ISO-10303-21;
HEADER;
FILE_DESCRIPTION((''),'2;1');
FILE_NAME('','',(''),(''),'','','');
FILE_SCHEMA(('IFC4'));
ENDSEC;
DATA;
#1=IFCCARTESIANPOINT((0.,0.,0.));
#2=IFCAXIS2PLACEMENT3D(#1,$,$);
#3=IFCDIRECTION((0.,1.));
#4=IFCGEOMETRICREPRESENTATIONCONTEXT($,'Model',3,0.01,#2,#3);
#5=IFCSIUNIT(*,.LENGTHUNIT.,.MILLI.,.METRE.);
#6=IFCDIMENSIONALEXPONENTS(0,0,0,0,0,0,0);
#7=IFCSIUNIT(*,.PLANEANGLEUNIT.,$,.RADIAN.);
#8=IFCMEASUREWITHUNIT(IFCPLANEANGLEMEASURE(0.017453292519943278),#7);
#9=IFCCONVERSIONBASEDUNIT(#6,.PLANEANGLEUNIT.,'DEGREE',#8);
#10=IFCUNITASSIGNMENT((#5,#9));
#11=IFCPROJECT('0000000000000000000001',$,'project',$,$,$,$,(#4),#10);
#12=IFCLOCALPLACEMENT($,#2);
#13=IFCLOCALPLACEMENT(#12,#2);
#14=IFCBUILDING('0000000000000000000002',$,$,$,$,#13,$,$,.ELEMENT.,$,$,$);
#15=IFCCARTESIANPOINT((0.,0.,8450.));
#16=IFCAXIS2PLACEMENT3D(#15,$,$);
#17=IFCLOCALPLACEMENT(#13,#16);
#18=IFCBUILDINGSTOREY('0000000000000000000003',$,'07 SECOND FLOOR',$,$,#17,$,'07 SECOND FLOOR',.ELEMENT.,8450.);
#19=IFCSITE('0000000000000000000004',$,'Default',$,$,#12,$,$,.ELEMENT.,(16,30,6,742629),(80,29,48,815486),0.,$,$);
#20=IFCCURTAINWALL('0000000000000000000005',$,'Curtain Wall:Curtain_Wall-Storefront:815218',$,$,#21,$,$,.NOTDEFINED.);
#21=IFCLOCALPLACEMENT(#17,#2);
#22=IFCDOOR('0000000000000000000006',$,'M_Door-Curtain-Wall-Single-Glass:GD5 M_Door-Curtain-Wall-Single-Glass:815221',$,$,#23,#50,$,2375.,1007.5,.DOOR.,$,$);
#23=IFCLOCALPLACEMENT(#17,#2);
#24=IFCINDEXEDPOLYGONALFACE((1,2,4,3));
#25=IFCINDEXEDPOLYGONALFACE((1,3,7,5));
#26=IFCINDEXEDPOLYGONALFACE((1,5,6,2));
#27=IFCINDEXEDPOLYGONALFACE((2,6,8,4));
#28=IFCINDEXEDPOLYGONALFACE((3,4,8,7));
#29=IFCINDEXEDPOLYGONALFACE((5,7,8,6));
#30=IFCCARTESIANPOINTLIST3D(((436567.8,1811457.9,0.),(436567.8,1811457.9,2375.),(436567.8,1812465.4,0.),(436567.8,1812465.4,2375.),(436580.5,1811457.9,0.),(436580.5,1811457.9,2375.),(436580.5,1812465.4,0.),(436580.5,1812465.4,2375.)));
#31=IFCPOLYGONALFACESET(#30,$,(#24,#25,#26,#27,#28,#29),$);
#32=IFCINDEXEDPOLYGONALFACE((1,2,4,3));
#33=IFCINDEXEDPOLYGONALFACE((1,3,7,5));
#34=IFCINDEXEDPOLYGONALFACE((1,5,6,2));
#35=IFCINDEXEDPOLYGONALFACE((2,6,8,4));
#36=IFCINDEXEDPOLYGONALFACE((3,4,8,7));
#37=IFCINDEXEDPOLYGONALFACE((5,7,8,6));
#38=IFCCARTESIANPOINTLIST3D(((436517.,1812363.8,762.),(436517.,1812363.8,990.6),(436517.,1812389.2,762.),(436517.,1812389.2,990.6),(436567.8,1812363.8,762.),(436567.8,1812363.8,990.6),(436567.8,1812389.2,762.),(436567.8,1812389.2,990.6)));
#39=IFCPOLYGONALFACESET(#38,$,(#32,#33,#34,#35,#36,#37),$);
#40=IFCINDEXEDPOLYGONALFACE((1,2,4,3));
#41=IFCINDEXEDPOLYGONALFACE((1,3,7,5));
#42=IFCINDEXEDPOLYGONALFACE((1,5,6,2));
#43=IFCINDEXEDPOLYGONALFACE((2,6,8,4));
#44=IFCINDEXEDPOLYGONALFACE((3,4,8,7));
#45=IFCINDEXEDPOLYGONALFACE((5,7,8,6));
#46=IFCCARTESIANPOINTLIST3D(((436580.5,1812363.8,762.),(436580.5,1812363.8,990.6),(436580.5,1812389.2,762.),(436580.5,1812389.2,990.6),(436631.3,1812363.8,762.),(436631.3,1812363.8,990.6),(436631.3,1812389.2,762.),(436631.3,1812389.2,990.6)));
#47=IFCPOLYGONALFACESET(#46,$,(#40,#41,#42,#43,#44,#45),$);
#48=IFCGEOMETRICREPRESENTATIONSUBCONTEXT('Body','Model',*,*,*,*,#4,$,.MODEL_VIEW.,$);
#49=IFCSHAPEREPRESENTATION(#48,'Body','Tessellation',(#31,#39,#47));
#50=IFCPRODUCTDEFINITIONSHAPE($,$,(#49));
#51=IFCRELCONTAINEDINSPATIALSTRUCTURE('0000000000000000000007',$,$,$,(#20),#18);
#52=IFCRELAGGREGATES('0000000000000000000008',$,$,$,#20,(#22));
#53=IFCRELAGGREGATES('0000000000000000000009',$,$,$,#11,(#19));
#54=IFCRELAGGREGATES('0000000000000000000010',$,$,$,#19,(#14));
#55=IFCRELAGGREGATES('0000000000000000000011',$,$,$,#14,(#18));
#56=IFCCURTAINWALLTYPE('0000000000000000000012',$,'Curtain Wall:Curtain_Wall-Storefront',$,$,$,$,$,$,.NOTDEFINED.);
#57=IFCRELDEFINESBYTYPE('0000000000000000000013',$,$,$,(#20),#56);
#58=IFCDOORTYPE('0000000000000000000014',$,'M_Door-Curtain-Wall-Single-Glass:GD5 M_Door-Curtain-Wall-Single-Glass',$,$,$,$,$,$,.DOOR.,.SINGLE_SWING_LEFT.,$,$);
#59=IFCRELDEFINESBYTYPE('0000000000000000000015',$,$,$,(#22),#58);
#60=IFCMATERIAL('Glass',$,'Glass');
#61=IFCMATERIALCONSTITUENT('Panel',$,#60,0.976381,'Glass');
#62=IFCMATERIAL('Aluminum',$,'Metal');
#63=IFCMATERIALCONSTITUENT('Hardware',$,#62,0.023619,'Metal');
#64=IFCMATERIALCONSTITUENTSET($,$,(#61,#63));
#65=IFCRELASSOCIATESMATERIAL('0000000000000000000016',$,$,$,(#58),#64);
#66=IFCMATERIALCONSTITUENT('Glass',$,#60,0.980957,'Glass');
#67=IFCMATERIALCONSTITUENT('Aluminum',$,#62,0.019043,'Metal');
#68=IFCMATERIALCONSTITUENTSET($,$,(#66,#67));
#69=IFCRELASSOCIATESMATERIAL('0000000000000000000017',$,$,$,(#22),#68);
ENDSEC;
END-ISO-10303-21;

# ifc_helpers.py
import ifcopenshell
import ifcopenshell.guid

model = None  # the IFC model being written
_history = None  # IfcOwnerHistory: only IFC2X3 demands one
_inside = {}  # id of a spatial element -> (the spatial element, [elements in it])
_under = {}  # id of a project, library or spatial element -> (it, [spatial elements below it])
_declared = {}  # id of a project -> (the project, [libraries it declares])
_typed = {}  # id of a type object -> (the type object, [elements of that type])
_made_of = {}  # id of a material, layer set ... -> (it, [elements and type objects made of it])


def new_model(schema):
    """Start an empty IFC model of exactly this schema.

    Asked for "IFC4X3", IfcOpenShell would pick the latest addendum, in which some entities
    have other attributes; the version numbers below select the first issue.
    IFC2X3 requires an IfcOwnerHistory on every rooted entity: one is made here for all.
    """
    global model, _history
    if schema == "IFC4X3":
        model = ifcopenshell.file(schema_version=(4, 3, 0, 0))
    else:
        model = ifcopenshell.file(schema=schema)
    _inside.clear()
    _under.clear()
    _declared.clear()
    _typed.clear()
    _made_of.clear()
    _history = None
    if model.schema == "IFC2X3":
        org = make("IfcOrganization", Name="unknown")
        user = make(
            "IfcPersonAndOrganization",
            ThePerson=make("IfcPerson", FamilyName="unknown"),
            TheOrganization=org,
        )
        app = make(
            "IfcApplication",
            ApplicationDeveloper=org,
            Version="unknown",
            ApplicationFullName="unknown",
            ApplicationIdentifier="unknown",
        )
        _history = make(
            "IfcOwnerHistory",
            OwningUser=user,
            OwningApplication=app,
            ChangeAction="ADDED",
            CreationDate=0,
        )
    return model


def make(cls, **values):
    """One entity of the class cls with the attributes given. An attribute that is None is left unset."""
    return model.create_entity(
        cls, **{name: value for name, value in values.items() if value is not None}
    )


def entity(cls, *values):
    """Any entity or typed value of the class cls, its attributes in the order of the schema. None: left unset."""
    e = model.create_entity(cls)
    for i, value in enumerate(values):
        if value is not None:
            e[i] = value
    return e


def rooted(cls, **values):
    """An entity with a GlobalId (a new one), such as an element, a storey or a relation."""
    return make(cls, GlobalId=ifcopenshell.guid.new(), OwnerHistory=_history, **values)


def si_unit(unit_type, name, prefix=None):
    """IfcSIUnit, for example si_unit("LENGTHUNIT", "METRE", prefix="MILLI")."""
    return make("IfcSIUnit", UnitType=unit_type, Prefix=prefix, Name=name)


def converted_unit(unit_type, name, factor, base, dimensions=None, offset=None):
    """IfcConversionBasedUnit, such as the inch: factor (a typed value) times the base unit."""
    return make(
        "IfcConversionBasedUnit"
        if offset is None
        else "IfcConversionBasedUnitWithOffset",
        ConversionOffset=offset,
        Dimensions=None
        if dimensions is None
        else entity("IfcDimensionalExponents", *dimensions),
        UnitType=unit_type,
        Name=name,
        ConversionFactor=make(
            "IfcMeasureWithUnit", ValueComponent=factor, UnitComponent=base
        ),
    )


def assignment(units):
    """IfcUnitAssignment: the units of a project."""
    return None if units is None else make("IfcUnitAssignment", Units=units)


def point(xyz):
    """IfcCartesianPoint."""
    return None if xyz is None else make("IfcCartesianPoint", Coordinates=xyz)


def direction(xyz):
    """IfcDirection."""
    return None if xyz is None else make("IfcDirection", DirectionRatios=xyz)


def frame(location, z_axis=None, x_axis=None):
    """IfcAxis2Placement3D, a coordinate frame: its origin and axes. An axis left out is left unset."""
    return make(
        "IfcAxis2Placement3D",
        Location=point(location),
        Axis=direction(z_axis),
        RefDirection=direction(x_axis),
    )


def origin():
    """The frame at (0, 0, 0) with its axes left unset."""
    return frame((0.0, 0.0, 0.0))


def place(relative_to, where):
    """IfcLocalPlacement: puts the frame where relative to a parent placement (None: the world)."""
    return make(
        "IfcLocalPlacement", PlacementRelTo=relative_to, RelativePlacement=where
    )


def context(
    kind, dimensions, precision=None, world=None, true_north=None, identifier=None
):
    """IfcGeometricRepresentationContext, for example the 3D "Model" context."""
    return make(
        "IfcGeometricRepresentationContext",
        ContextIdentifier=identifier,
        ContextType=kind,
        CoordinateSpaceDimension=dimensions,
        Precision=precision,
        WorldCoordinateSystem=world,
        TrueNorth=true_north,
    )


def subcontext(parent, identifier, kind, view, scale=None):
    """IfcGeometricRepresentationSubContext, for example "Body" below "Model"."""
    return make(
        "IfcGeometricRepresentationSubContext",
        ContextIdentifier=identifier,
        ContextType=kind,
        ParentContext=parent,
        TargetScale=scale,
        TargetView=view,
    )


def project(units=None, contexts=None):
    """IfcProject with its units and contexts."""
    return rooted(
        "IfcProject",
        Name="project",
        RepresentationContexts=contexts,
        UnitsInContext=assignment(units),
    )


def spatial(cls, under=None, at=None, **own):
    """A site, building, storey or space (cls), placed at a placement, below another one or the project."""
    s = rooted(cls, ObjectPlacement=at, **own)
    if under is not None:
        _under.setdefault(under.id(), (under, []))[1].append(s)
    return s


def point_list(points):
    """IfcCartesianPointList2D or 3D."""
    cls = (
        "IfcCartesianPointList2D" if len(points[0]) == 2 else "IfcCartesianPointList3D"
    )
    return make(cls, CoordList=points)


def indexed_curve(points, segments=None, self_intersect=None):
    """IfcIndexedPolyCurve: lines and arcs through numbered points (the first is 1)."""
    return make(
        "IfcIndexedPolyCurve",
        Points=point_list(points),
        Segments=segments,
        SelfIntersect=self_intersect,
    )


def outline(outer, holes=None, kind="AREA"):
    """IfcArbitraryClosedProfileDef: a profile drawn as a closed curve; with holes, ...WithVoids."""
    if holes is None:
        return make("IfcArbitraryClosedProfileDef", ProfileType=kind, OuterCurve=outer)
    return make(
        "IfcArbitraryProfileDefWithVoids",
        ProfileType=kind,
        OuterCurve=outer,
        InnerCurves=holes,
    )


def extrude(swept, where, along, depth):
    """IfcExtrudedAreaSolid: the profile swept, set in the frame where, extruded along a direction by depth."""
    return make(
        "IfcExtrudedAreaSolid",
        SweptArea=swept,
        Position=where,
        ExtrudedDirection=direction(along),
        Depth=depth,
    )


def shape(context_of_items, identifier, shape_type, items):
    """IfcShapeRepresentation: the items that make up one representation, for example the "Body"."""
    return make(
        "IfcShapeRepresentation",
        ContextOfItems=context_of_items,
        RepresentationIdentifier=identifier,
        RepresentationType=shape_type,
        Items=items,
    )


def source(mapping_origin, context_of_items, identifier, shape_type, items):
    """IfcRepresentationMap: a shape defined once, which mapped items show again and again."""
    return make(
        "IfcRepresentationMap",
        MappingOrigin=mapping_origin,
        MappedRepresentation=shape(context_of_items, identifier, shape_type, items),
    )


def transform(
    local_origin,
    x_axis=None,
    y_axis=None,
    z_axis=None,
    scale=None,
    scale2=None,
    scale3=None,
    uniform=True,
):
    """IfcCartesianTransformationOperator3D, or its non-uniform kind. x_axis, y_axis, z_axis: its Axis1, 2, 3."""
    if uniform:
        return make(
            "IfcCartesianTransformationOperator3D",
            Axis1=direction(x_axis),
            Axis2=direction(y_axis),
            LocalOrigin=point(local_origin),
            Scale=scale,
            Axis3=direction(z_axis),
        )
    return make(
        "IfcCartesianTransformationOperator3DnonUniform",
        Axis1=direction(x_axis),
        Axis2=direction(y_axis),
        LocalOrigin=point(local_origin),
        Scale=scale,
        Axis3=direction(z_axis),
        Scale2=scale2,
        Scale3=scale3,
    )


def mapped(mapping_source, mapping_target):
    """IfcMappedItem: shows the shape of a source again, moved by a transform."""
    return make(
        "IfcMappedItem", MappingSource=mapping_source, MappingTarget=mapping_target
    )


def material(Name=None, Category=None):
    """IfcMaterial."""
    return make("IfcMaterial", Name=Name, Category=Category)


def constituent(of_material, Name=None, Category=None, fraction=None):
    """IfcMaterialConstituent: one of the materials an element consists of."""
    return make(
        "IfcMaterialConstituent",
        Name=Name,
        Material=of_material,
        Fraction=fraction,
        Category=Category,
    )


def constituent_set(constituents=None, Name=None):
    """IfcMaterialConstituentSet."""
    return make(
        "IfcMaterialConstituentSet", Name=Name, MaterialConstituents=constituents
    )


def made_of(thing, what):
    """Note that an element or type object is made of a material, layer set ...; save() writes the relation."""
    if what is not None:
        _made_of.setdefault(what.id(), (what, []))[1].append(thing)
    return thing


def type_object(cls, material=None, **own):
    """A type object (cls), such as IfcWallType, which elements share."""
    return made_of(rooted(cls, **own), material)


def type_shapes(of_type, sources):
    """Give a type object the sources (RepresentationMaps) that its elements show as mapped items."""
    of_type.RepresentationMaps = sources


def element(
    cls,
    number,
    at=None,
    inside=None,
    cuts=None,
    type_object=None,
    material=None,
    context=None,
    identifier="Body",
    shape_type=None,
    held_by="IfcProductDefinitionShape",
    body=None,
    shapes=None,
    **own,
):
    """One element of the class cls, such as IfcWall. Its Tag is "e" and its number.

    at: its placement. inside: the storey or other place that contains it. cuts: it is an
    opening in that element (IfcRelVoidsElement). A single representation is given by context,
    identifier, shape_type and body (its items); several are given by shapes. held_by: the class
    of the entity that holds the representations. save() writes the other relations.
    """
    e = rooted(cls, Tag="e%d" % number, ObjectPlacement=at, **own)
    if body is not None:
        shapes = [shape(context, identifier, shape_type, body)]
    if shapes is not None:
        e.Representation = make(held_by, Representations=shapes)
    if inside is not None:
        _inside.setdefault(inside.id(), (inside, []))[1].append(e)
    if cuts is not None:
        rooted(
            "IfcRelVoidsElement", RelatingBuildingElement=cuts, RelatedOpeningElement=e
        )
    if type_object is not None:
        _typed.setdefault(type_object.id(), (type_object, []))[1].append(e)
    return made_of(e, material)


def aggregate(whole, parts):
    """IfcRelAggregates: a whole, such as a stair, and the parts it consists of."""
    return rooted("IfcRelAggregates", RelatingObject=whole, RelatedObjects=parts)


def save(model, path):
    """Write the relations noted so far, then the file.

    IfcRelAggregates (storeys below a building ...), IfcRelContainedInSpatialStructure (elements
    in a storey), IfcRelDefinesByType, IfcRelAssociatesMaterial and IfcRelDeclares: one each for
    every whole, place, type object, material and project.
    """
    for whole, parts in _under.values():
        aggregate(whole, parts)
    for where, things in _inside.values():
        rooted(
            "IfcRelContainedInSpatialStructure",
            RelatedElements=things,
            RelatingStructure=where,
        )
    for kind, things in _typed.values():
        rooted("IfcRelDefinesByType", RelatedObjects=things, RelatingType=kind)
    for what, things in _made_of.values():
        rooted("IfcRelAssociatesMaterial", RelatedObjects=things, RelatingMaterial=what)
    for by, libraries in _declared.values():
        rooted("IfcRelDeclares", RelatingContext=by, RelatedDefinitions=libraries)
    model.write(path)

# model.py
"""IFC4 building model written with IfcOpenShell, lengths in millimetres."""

from ifc_helpers import new_model, entity, si_unit, converted_unit, direction, frame, origin, place, context, subcontext, project, spatial, indexed_curve, outline, extrude, source, transform, mapped, material, constituent, constituent_set, type_object, type_shapes, element, aggregate, save


model = new_model("IFC4")

# Units and contexts
model_context = context("Model", 3, precision=0.01, world=origin(), true_north=direction((0.0, 1.0)))
body_context = subcontext(model_context, "Body", "Model", "MODEL_VIEW")
ifc_project = project(units=[si_unit("LENGTHUNIT", "METRE", prefix="MILLI"), converted_unit("PLANEANGLEUNIT", "DEGREE", entity("IfcPlaneAngleMeasure", 0.017453292519943278), si_unit("PLANEANGLEUNIT", "RADIAN"), dimensions=[0, 0, 0, 0, 0, 0, 0])], contexts=[model_context])

# Site, building, storey
site_placement = place(None, origin())
site = spatial("IfcSite", under=ifc_project, at=site_placement, Name="Default", CompositionType="ELEMENT", RefLatitude=(16, 30, 6, 742629), RefLongitude=(80, 29, 48, 815486), RefElevation=0.0)
building_placement = place(site_placement, origin())
building = spatial("IfcBuilding", under=site, at=building_placement, CompositionType="ELEMENT")
storey_placement = place(building_placement, frame((0.0, 0.0, 8450.0)))
storey = spatial("IfcBuildingStorey", under=building, at=storey_placement, Name="07 SECOND FLOOR", LongName="07 SECOND FLOOR", CompositionType="ELEMENT", Elevation=8450.0)

# Curtain wall
curtain_wall_type = type_object("IfcCurtainWallType", Name="Curtain Wall:Curtain_Wall-Storefront", PredefinedType="NOTDEFINED")
curtain_wall_placement = place(storey_placement, frame((0.0, 0.0, -8450.0)))
curtain_wall = element("IfcCurtainWall", 1, at=curtain_wall_placement, inside=storey, type_object=curtain_wall_type, Name="Curtain Wall:Curtain_Wall-Storefront:815218", PredefinedType="NOTDEFINED")
ifc_material_1 = material(Name="Glass", Category="Glass")

# Door
ifc_constituent_1 = constituent(ifc_material_1, Name="Glass", Category="Glass", fraction=0.980957)
ifc_material_2 = material(Name="Aluminum", Category="Metal")
ifc_constituent_2 = constituent(ifc_material_2, Name="Aluminum", Category="Metal", fraction=0.019043)
ifc_constituent_set_1 = constituent_set(constituents=[ifc_constituent_1, ifc_constituent_2])
ifc_constituent_3 = constituent(ifc_material_1, Name="Panel", Category="Glass", fraction=0.976381)
ifc_constituent_4 = constituent(ifc_material_2, Name="Hardware", Category="Metal", fraction=0.023619)
ifc_constituent_set_2 = constituent_set(constituents=[ifc_constituent_3, ifc_constituent_4])
door_type = type_object("IfcDoorType", Name="M_Door-Curtain-Wall-Single-Glass:GD5 M_Door-Curtain-Wall-Single-Glass", OperationType="SINGLE_SWING_LEFT", PredefinedType="DOOR", material=ifc_constituent_set_2)
shared_shape_1 = source(origin(), body_context, "Body", "SweptSolid", [
    extrude(outline(indexed_curve([(-6.4, -503.8), (6.4, -503.8), (6.4, 503.8), (-6.4, 503.8), (-6.4, -503.8)], self_intersect=False)), frame((0.0, 44.5, 0.0), z_axis=(0.0, 0.0, 1.0), x_axis=(0.0, -1.0, 0.0)), (0.0, 0.0, 1.0), 2375.0),
    extrude(outline(indexed_curve([(-12.7, -25.4), (12.7, -25.4), (12.7, 25.4), (-12.7, 25.4), (-12.7, -25.4)], self_intersect=False)), frame((414.9, 76.2, 762.0), z_axis=(0.0, 0.0, 1.0), x_axis=(-1.0, 0.0, 0.0)), (0.0, 0.0, 1.0), 228.6),
    extrude(outline(indexed_curve([(-12.7, -25.4), (12.7, -25.4), (12.7, 25.4), (-12.7, 25.4), (-12.7, -25.4)], self_intersect=False)), frame((414.9, 12.7, 762.0)), (0.0, 0.0, 1.0), 228.6),
])
type_shapes(door_type, [shared_shape_1])
door_placement = place(curtain_wall_placement, frame((436618.6, 1811961.7, 8450.0), z_axis=(0.0, 0.0, 1.0), x_axis=(0.0, 1.0, 0.0)))
door = element("IfcDoor", 2, at=door_placement, type_object=door_type, material=ifc_constituent_set_1, Name="M_Door-Curtain-Wall-Single-Glass:GD5 M_Door-Curtain-Wall-Single-Glass:815221", OverallHeight=2375.0, OverallWidth=1007.5, PredefinedType="DOOR", context=body_context, shape_type="MappedRepresentation", body=[
    mapped(shared_shape_1, transform((0.0, 0.0, 0.0), scale=1.0)),
])
aggregate(curtain_wall, [door])

save(model, "model.ifc")
